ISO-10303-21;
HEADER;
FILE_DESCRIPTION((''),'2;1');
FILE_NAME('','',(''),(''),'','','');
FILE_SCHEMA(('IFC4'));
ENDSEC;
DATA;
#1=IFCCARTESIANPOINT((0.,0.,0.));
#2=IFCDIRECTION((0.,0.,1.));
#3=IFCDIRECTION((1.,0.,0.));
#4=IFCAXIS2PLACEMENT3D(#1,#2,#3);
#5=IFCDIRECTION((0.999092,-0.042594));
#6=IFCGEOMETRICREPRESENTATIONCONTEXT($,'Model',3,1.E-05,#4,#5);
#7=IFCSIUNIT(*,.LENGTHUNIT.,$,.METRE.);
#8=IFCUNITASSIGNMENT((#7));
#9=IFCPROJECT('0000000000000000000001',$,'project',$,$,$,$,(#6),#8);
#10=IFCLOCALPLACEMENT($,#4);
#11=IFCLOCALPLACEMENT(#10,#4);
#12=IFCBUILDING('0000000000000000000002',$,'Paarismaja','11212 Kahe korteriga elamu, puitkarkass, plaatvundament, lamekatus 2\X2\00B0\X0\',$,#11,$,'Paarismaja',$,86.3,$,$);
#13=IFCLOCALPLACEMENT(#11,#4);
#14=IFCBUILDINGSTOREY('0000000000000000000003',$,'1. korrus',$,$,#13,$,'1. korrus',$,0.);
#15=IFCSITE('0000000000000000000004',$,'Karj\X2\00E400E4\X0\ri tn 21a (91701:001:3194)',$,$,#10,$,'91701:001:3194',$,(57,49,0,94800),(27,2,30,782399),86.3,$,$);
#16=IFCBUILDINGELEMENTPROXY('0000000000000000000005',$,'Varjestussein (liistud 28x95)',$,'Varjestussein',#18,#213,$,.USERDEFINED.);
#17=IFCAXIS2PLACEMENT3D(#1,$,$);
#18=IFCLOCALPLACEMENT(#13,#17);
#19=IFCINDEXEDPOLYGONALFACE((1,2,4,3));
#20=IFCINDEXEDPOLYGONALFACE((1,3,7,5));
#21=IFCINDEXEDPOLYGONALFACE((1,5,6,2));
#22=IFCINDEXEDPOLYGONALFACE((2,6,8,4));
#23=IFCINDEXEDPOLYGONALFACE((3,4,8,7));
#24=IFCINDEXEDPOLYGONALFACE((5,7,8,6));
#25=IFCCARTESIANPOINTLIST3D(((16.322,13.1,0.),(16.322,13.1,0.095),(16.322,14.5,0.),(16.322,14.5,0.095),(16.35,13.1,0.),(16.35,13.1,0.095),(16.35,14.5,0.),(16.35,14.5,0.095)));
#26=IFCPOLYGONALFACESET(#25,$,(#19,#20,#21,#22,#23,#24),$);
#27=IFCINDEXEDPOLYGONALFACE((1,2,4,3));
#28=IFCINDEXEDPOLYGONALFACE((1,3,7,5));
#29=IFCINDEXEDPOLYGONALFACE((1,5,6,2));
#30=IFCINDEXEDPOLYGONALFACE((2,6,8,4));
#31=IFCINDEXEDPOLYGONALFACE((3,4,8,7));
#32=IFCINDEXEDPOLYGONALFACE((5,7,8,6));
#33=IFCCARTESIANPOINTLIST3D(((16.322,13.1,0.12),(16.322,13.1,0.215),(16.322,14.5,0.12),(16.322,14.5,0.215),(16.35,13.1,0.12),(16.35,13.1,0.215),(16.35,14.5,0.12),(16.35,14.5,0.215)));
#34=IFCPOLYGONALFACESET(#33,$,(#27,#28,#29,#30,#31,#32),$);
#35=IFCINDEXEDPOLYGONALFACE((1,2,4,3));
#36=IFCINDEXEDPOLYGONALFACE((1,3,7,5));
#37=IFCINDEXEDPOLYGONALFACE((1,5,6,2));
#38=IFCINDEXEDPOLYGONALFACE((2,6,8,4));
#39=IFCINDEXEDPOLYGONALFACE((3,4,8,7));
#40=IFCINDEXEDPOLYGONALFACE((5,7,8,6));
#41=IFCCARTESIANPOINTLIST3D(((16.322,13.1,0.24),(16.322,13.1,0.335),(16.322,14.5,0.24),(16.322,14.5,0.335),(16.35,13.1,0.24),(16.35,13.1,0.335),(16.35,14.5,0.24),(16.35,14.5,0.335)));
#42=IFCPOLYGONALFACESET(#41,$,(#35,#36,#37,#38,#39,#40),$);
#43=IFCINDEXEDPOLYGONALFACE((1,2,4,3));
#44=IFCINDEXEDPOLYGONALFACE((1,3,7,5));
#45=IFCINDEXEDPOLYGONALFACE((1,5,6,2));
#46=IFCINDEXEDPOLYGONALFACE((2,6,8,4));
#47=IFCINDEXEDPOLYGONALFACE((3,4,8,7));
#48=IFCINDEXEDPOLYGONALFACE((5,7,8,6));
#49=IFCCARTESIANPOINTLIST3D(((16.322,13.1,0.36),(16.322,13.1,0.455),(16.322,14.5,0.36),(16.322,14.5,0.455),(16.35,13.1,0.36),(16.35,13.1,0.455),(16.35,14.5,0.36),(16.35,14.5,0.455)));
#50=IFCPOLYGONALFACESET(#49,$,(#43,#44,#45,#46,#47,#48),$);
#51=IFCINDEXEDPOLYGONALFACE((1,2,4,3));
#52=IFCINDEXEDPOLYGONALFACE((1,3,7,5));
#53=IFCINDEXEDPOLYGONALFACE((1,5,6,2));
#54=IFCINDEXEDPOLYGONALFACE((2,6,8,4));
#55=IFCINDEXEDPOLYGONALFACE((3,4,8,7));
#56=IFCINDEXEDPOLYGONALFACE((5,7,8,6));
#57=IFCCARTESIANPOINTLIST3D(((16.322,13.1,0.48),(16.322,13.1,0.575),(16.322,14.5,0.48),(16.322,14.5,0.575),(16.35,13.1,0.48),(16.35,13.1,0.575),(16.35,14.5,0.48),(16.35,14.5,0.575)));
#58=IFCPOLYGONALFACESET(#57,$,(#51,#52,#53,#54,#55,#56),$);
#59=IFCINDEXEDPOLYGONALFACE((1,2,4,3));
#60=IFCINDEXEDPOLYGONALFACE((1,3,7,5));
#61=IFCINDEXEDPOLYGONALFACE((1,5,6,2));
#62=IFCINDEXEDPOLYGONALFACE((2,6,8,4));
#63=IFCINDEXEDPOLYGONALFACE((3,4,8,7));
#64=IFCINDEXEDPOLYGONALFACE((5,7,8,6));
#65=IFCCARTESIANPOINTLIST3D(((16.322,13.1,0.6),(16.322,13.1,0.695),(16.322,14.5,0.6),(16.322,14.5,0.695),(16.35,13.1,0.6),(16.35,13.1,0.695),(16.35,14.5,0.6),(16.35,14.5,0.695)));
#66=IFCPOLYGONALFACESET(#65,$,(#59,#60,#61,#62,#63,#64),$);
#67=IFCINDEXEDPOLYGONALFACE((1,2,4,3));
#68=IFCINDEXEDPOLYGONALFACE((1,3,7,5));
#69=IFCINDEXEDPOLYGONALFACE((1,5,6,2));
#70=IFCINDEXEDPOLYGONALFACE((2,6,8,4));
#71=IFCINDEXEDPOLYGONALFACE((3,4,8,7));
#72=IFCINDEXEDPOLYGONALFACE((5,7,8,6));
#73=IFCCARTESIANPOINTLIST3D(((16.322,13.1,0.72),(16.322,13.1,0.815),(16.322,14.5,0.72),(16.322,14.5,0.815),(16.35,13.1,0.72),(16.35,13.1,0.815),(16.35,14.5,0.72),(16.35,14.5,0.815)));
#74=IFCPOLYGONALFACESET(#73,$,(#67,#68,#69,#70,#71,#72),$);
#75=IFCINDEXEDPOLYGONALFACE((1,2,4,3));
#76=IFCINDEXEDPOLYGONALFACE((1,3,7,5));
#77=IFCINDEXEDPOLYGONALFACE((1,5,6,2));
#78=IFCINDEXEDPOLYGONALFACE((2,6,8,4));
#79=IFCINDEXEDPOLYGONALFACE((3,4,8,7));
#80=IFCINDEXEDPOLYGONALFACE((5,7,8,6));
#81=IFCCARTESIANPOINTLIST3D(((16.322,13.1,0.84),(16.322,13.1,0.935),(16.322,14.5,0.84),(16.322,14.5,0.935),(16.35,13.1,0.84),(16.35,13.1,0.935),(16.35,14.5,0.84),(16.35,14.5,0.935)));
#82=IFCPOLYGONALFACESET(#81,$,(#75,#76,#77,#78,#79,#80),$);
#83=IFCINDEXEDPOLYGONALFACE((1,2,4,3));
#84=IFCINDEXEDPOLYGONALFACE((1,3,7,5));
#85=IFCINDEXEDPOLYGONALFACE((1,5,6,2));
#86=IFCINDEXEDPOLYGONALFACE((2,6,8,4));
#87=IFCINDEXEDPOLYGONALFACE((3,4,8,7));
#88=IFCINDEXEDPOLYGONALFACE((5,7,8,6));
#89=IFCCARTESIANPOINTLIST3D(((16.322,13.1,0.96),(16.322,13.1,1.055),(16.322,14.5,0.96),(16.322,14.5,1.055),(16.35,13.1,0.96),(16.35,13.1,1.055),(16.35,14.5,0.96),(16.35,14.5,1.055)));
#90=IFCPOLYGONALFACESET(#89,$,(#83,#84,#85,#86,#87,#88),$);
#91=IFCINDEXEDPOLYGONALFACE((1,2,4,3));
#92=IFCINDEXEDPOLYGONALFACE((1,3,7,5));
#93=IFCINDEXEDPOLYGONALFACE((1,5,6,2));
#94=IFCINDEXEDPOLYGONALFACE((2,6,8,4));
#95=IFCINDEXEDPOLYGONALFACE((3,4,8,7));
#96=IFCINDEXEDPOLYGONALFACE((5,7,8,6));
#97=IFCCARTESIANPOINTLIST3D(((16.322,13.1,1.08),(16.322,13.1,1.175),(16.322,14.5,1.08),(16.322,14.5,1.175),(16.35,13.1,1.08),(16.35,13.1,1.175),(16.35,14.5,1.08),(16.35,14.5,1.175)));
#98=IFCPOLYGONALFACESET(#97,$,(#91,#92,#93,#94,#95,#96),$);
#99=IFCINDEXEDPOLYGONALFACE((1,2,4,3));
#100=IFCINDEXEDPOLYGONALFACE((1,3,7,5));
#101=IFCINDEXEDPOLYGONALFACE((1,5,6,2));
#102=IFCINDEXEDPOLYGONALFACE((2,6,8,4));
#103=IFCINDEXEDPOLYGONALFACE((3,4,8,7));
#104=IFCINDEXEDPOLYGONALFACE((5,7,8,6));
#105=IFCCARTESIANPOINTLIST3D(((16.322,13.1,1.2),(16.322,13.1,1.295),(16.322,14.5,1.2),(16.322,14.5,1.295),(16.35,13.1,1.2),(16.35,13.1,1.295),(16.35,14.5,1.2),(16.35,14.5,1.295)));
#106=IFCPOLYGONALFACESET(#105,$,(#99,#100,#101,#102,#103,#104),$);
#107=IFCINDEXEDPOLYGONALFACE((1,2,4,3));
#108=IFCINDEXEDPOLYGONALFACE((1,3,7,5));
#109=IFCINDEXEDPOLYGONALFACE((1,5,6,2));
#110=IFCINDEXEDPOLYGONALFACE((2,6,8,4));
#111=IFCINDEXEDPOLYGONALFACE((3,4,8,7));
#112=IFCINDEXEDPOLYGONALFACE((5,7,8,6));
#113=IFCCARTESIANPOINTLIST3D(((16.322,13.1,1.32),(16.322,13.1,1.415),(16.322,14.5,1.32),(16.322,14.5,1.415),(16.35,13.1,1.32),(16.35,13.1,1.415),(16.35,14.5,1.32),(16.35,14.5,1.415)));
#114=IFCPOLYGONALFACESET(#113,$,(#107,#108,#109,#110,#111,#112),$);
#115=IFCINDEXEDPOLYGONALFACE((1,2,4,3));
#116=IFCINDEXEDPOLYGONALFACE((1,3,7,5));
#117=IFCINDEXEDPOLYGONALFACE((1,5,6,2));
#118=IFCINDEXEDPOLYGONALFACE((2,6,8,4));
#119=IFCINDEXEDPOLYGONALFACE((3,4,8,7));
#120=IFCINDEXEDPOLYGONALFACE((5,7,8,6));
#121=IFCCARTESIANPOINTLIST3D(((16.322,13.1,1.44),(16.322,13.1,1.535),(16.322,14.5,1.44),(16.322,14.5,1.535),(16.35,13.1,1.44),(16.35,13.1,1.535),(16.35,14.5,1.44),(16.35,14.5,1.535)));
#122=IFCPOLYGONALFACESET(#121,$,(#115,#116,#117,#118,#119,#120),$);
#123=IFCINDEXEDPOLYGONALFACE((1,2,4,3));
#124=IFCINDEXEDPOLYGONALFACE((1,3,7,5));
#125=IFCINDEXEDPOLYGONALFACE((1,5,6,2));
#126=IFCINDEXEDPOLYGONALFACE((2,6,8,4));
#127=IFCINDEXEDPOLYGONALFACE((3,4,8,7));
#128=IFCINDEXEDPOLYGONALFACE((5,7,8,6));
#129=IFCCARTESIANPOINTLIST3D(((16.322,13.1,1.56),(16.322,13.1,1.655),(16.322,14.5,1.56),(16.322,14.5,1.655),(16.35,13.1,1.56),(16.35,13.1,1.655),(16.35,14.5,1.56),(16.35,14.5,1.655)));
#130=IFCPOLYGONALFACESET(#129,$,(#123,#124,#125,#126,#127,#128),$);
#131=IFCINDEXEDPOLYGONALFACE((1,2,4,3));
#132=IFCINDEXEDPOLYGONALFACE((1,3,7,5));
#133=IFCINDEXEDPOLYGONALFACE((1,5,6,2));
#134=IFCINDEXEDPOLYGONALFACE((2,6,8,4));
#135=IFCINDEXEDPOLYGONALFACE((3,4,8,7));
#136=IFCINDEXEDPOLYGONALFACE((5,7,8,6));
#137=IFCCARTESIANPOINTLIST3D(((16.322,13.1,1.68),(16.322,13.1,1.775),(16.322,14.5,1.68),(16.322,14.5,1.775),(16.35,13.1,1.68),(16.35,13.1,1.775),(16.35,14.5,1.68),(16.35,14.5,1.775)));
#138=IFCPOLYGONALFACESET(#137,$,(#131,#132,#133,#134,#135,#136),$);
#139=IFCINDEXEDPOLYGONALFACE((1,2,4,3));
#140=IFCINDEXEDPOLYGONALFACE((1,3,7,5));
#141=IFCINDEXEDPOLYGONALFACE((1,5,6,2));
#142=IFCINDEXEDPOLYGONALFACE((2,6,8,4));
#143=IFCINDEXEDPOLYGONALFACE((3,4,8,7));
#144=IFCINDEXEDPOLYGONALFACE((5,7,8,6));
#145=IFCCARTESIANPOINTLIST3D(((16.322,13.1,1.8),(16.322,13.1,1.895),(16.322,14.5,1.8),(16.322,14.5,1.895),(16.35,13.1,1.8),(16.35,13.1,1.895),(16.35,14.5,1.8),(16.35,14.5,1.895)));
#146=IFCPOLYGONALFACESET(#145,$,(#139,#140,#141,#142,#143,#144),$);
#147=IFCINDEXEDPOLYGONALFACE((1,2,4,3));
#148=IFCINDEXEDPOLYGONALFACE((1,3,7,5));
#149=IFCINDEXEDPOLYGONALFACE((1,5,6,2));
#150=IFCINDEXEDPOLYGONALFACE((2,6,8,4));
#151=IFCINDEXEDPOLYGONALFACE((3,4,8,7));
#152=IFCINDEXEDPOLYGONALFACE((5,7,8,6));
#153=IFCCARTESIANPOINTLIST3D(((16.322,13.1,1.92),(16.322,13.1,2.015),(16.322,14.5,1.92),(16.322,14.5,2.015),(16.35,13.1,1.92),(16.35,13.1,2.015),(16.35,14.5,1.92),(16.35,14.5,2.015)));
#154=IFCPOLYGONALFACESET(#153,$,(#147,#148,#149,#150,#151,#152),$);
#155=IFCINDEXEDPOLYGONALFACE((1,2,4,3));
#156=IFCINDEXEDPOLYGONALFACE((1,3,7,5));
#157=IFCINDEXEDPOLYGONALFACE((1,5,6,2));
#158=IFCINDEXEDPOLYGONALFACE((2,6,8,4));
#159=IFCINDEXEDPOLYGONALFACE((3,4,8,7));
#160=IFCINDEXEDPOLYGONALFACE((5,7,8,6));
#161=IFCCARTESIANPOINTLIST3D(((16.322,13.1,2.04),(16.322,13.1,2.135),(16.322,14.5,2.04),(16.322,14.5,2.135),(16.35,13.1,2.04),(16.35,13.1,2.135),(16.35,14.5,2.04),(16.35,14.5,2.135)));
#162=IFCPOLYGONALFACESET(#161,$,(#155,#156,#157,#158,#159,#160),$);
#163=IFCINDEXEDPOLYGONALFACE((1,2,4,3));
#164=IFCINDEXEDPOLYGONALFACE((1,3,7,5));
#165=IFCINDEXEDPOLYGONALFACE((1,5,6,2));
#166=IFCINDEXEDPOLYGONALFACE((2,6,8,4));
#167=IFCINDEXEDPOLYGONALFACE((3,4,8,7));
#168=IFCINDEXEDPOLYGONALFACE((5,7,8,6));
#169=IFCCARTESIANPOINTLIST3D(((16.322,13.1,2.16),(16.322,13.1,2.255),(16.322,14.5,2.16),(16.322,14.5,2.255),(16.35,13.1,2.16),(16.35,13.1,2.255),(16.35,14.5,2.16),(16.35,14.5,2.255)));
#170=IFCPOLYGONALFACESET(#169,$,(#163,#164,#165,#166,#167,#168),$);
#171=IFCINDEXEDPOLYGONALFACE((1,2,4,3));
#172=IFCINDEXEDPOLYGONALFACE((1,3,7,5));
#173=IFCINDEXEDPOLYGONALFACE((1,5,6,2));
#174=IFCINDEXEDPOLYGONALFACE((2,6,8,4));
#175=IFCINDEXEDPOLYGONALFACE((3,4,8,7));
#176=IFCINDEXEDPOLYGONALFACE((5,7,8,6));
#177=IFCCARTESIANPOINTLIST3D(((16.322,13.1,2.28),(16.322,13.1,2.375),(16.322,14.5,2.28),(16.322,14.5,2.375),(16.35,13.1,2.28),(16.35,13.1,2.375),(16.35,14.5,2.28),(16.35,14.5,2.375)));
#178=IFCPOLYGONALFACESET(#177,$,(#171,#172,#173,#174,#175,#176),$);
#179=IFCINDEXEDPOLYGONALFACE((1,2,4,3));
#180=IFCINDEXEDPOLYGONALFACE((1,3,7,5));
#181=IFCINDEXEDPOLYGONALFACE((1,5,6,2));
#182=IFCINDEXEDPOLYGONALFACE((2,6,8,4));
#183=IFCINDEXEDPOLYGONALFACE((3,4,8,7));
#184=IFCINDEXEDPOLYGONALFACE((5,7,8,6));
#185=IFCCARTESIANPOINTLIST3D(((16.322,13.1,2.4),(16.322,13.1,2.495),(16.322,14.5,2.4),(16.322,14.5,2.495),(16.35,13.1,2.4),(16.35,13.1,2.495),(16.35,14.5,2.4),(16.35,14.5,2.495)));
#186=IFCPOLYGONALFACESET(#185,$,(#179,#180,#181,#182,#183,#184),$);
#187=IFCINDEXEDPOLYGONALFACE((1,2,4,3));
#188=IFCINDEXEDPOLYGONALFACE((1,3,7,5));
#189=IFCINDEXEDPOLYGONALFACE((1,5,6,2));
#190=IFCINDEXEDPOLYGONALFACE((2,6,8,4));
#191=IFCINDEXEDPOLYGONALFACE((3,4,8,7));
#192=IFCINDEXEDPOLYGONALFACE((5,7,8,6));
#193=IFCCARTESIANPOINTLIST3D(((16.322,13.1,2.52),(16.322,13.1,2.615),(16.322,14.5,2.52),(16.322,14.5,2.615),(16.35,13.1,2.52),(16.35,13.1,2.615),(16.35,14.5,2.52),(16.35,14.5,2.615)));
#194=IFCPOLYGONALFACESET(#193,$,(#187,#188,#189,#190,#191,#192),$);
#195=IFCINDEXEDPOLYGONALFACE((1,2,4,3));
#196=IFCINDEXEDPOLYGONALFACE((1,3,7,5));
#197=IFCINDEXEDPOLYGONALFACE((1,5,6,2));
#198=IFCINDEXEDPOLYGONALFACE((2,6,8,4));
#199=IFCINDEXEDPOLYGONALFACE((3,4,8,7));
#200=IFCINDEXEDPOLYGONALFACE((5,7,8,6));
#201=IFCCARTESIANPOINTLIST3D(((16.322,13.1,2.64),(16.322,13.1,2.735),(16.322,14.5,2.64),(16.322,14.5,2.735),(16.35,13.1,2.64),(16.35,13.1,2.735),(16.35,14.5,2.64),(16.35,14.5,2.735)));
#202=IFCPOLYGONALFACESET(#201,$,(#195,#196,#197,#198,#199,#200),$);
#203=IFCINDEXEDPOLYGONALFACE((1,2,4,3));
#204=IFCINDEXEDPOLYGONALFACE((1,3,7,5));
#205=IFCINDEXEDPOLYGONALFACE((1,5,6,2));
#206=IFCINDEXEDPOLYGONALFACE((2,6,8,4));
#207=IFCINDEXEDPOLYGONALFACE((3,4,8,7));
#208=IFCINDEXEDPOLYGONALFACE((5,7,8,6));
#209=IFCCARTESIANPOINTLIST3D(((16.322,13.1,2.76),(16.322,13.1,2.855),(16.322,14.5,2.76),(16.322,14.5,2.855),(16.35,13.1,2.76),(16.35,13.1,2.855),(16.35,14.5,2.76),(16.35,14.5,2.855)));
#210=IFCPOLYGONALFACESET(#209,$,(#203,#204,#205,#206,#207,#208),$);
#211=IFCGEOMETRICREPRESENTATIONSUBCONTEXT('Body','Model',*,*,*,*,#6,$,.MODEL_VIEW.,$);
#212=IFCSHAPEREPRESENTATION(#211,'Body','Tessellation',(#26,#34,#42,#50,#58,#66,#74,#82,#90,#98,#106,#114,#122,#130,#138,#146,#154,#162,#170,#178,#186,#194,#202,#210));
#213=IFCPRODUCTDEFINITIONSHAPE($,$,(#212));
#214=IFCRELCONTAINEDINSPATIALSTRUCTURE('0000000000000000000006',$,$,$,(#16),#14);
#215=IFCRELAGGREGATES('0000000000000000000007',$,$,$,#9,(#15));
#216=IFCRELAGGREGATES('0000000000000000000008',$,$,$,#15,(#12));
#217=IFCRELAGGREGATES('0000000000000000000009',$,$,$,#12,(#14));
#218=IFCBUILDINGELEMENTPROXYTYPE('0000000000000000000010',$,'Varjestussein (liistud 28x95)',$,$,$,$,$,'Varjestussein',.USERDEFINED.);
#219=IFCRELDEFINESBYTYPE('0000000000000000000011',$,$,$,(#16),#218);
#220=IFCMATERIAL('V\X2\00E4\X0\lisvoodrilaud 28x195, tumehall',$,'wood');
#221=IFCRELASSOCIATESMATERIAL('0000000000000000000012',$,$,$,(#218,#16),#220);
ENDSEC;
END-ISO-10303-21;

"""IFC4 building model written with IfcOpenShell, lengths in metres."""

from ifc_helpers import new_model, si_unit, direction, frame, origin_with_axes, place, context, subcontext, project, spatial, indexed_curve, outline, extrude, material, type_object, element, save


model = new_model("IFC4")

# Units and contexts
model_context = context("Model", 3, precision=1e-05, world=origin_with_axes(), true_north=direction((0.999092, -0.042594)))
body_context = subcontext(model_context, "Body", "Model", "MODEL_VIEW")
ifc_project = project(units=[si_unit("LENGTHUNIT", "METRE")], contexts=[model_context])

# Site, building, storey
site_placement = place(None, origin_with_axes())
site = spatial("IfcSite", under=ifc_project, at=site_placement, Name="Karjääri tn 21a (91701:001:3194)", LongName="91701:001:3194", RefLatitude=(57, 49, 0, 94800), RefLongitude=(27, 2, 30, 782399), RefElevation=86.3)
building_placement = place(site_placement, origin_with_axes())
building = spatial("IfcBuilding", under=site, at=building_placement, Name="Paarismaja", Description="11212 Kahe korteriga elamu, puitkarkass, plaatvundament, lamekatus 2°", LongName="Paarismaja", ElevationOfRefHeight=86.3)
storey_placement = place(building_placement, origin_with_axes())
storey = spatial("IfcBuildingStorey", under=building, at=storey_placement, Name="1. korrus", LongName="1. korrus", Elevation=0.0)

# Building element proxy
ifc_material_1 = material(Name="Välisvoodrilaud 28x195, tumehall", Category="wood")
building_element_proxy_type_1 = type_object("IfcBuildingElementProxyType", Name="Varjestussein (liistud 28x95)", ElementType="Varjestussein", PredefinedType="USERDEFINED", material=ifc_material_1)
proxy_1_placement = place(storey_placement, origin_with_axes())
element("IfcBuildingElementProxy", 1, at=proxy_1_placement, inside=storey, type_object=building_element_proxy_type_1, material=ifc_material_1, Name="Varjestussein (liistud 28x95)", ObjectType="Varjestussein", PredefinedType="USERDEFINED", context=body_context, shape_type="SweptSolid", body=[
    extrude(outline(indexed_curve([(16.322, 13.1), (16.35, 13.1), (16.35, 14.5), (16.322, 14.5), (16.322, 13.1)], self_intersect=False)), origin_with_axes(), (0.0, 0.0, 1.0), 0.095),
    extrude(outline(indexed_curve([(16.322, 13.1), (16.35, 13.1), (16.35, 14.5), (16.322, 14.5), (16.322, 13.1)], self_intersect=False)), frame((0.0, 0.0, 0.12), z_axis=(0.0, 0.0, 1.0), x_axis=(1.0, 0.0, 0.0)), (0.0, 0.0, 1.0), 0.095),
    extrude(outline(indexed_curve([(16.322, 13.1), (16.35, 13.1), (16.35, 14.5), (16.322, 14.5), (16.322, 13.1)], self_intersect=False)), frame((0.0, 0.0, 0.24), z_axis=(0.0, 0.0, 1.0), x_axis=(1.0, 0.0, 0.0)), (0.0, 0.0, 1.0), 0.095),
    extrude(outline(indexed_curve([(16.322, 13.1), (16.35, 13.1), (16.35, 14.5), (16.322, 14.5), (16.322, 13.1)], self_intersect=False)), frame((0.0, 0.0, 0.36), z_axis=(0.0, 0.0, 1.0), x_axis=(1.0, 0.0, 0.0)), (0.0, 0.0, 1.0), 0.095),
    extrude(outline(indexed_curve([(16.322, 13.1), (16.35, 13.1), (16.35, 14.5), (16.322, 14.5), (16.322, 13.1)], self_intersect=False)), frame((0.0, 0.0, 0.48), z_axis=(0.0, 0.0, 1.0), x_axis=(1.0, 0.0, 0.0)), (0.0, 0.0, 1.0), 0.095),
    extrude(outline(indexed_curve([(16.322, 13.1), (16.35, 13.1), (16.35, 14.5), (16.322, 14.5), (16.322, 13.1)], self_intersect=False)), frame((0.0, 0.0, 0.6), z_axis=(0.0, 0.0, 1.0), x_axis=(1.0, 0.0, 0.0)), (0.0, 0.0, 1.0), 0.095),
    extrude(outline(indexed_curve([(16.322, 13.1), (16.35, 13.1), (16.35, 14.5), (16.322, 14.5), (16.322, 13.1)], self_intersect=False)), frame((0.0, 0.0, 0.72), z_axis=(0.0, 0.0, 1.0), x_axis=(1.0, 0.0, 0.0)), (0.0, 0.0, 1.0), 0.095),
    extrude(outline(indexed_curve([(16.322, 13.1), (16.35, 13.1), (16.35, 14.5), (16.322, 14.5), (16.322, 13.1)], self_intersect=False)), frame((0.0, 0.0, 0.84), z_axis=(0.0, 0.0, 1.0), x_axis=(1.0, 0.0, 0.0)), (0.0, 0.0, 1.0), 0.095),
    extrude(outline(indexed_curve([(16.322, 13.1), (16.35, 13.1), (16.35, 14.5), (16.322, 14.5), (16.322, 13.1)], self_intersect=False)), frame((0.0, 0.0, 0.96), z_axis=(0.0, 0.0, 1.0), x_axis=(1.0, 0.0, 0.0)), (0.0, 0.0, 1.0), 0.095),
    extrude(outline(indexed_curve([(16.322, 13.1), (16.35, 13.1), (16.35, 14.5), (16.322, 14.5), (16.322, 13.1)], self_intersect=False)), frame((0.0, 0.0, 1.08), z_axis=(0.0, 0.0, 1.0), x_axis=(1.0, 0.0, 0.0)), (0.0, 0.0, 1.0), 0.095),
    extrude(outline(indexed_curve([(16.322, 13.1), (16.35, 13.1), (16.35, 14.5), (16.322, 14.5), (16.322, 13.1)], self_intersect=False)), frame((0.0, 0.0, 1.2), z_axis=(0.0, 0.0, 1.0), x_axis=(1.0, 0.0, 0.0)), (0.0, 0.0, 1.0), 0.095),
    extrude(outline(indexed_curve([(16.322, 13.1), (16.35, 13.1), (16.35, 14.5), (16.322, 14.5), (16.322, 13.1)], self_intersect=False)), frame((0.0, 0.0, 1.32), z_axis=(0.0, 0.0, 1.0), x_axis=(1.0, 0.0, 0.0)), (0.0, 0.0, 1.0), 0.095),
    extrude(outline(indexed_curve([(16.322, 13.1), (16.35, 13.1), (16.35, 14.5), (16.322, 14.5), (16.322, 13.1)], self_intersect=False)), frame((0.0, 0.0, 1.44), z_axis=(0.0, 0.0, 1.0), x_axis=(1.0, 0.0, 0.0)), (0.0, 0.0, 1.0), 0.095),
    extrude(outline(indexed_curve([(16.322, 13.1), (16.35, 13.1), (16.35, 14.5), (16.322, 14.5), (16.322, 13.1)], self_intersect=False)), frame((0.0, 0.0, 1.56), z_axis=(0.0, 0.0, 1.0), x_axis=(1.0, 0.0, 0.0)), (0.0, 0.0, 1.0), 0.095),
    extrude(outline(indexed_curve([(16.322, 13.1), (16.35, 13.1), (16.35, 14.5), (16.322, 14.5), (16.322, 13.1)], self_intersect=False)), frame((0.0, 0.0, 1.68), z_axis=(0.0, 0.0, 1.0), x_axis=(1.0, 0.0, 0.0)), (0.0, 0.0, 1.0), 0.095),
    extrude(outline(indexed_curve([(16.322, 13.1), (16.35, 13.1), (16.35, 14.5), (16.322, 14.5), (16.322, 13.1)], self_intersect=False)), frame((0.0, 0.0, 1.8), z_axis=(0.0, 0.0, 1.0), x_axis=(1.0, 0.0, 0.0)), (0.0, 0.0, 1.0), 0.095),
    extrude(outline(indexed_curve([(16.322, 13.1), (16.35, 13.1), (16.35, 14.5), (16.322, 14.5), (16.322, 13.1)], self_intersect=False)), frame((0.0, 0.0, 1.92), z_axis=(0.0, 0.0, 1.0), x_axis=(1.0, 0.0, 0.0)), (0.0, 0.0, 1.0), 0.095),
    extrude(outline(indexed_curve([(16.322, 13.1), (16.35, 13.1), (16.35, 14.5), (16.322, 14.5), (16.322, 13.1)], self_intersect=False)), frame((0.0, 0.0, 2.04), z_axis=(0.0, 0.0, 1.0), x_axis=(1.0, 0.0, 0.0)), (0.0, 0.0, 1.0), 0.095),
    extrude(outline(indexed_curve([(16.322, 13.1), (16.35, 13.1), (16.35, 14.5), (16.322, 14.5), (16.322, 13.1)], self_intersect=False)), frame((0.0, 0.0, 2.16), z_axis=(0.0, 0.0, 1.0), x_axis=(1.0, 0.0, 0.0)), (0.0, 0.0, 1.0), 0.095),
    extrude(outline(indexed_curve([(16.322, 13.1), (16.35, 13.1), (16.35, 14.5), (16.322, 14.5), (16.322, 13.1)], self_intersect=False)), frame((0.0, 0.0, 2.28), z_axis=(0.0, 0.0, 1.0), x_axis=(1.0, 0.0, 0.0)), (0.0, 0.0, 1.0), 0.095),
    extrude(outline(indexed_curve([(16.322, 13.1), (16.35, 13.1), (16.35, 14.5), (16.322, 14.5), (16.322, 13.1)], self_intersect=False)), frame((0.0, 0.0, 2.4), z_axis=(0.0, 0.0, 1.0), x_axis=(1.0, 0.0, 0.0)), (0.0, 0.0, 1.0), 0.095),
    extrude(outline(indexed_curve([(16.322, 13.1), (16.35, 13.1), (16.35, 14.5), (16.322, 14.5), (16.322, 13.1)], self_intersect=False)), frame((0.0, 0.0, 2.52), z_axis=(0.0, 0.0, 1.0), x_axis=(1.0, 0.0, 0.0)), (0.0, 0.0, 1.0), 0.095),
    extrude(outline(indexed_curve([(16.322, 13.1), (16.35, 13.1), (16.35, 14.5), (16.322, 14.5), (16.322, 13.1)], self_intersect=False)), frame((0.0, 0.0, 2.64), z_axis=(0.0, 0.0, 1.0), x_axis=(1.0, 0.0, 0.0)), (0.0, 0.0, 1.0), 0.095),
    extrude(outline(indexed_curve([(16.322, 13.1), (16.35, 13.1), (16.35, 14.5), (16.322, 14.5), (16.322, 13.1)], self_intersect=False)), frame((0.0, 0.0, 2.76), z_axis=(0.0, 0.0, 1.0), x_axis=(1.0, 0.0, 0.0)), (0.0, 0.0, 1.0), 0.095),
])

save(model, "model.ifc")
